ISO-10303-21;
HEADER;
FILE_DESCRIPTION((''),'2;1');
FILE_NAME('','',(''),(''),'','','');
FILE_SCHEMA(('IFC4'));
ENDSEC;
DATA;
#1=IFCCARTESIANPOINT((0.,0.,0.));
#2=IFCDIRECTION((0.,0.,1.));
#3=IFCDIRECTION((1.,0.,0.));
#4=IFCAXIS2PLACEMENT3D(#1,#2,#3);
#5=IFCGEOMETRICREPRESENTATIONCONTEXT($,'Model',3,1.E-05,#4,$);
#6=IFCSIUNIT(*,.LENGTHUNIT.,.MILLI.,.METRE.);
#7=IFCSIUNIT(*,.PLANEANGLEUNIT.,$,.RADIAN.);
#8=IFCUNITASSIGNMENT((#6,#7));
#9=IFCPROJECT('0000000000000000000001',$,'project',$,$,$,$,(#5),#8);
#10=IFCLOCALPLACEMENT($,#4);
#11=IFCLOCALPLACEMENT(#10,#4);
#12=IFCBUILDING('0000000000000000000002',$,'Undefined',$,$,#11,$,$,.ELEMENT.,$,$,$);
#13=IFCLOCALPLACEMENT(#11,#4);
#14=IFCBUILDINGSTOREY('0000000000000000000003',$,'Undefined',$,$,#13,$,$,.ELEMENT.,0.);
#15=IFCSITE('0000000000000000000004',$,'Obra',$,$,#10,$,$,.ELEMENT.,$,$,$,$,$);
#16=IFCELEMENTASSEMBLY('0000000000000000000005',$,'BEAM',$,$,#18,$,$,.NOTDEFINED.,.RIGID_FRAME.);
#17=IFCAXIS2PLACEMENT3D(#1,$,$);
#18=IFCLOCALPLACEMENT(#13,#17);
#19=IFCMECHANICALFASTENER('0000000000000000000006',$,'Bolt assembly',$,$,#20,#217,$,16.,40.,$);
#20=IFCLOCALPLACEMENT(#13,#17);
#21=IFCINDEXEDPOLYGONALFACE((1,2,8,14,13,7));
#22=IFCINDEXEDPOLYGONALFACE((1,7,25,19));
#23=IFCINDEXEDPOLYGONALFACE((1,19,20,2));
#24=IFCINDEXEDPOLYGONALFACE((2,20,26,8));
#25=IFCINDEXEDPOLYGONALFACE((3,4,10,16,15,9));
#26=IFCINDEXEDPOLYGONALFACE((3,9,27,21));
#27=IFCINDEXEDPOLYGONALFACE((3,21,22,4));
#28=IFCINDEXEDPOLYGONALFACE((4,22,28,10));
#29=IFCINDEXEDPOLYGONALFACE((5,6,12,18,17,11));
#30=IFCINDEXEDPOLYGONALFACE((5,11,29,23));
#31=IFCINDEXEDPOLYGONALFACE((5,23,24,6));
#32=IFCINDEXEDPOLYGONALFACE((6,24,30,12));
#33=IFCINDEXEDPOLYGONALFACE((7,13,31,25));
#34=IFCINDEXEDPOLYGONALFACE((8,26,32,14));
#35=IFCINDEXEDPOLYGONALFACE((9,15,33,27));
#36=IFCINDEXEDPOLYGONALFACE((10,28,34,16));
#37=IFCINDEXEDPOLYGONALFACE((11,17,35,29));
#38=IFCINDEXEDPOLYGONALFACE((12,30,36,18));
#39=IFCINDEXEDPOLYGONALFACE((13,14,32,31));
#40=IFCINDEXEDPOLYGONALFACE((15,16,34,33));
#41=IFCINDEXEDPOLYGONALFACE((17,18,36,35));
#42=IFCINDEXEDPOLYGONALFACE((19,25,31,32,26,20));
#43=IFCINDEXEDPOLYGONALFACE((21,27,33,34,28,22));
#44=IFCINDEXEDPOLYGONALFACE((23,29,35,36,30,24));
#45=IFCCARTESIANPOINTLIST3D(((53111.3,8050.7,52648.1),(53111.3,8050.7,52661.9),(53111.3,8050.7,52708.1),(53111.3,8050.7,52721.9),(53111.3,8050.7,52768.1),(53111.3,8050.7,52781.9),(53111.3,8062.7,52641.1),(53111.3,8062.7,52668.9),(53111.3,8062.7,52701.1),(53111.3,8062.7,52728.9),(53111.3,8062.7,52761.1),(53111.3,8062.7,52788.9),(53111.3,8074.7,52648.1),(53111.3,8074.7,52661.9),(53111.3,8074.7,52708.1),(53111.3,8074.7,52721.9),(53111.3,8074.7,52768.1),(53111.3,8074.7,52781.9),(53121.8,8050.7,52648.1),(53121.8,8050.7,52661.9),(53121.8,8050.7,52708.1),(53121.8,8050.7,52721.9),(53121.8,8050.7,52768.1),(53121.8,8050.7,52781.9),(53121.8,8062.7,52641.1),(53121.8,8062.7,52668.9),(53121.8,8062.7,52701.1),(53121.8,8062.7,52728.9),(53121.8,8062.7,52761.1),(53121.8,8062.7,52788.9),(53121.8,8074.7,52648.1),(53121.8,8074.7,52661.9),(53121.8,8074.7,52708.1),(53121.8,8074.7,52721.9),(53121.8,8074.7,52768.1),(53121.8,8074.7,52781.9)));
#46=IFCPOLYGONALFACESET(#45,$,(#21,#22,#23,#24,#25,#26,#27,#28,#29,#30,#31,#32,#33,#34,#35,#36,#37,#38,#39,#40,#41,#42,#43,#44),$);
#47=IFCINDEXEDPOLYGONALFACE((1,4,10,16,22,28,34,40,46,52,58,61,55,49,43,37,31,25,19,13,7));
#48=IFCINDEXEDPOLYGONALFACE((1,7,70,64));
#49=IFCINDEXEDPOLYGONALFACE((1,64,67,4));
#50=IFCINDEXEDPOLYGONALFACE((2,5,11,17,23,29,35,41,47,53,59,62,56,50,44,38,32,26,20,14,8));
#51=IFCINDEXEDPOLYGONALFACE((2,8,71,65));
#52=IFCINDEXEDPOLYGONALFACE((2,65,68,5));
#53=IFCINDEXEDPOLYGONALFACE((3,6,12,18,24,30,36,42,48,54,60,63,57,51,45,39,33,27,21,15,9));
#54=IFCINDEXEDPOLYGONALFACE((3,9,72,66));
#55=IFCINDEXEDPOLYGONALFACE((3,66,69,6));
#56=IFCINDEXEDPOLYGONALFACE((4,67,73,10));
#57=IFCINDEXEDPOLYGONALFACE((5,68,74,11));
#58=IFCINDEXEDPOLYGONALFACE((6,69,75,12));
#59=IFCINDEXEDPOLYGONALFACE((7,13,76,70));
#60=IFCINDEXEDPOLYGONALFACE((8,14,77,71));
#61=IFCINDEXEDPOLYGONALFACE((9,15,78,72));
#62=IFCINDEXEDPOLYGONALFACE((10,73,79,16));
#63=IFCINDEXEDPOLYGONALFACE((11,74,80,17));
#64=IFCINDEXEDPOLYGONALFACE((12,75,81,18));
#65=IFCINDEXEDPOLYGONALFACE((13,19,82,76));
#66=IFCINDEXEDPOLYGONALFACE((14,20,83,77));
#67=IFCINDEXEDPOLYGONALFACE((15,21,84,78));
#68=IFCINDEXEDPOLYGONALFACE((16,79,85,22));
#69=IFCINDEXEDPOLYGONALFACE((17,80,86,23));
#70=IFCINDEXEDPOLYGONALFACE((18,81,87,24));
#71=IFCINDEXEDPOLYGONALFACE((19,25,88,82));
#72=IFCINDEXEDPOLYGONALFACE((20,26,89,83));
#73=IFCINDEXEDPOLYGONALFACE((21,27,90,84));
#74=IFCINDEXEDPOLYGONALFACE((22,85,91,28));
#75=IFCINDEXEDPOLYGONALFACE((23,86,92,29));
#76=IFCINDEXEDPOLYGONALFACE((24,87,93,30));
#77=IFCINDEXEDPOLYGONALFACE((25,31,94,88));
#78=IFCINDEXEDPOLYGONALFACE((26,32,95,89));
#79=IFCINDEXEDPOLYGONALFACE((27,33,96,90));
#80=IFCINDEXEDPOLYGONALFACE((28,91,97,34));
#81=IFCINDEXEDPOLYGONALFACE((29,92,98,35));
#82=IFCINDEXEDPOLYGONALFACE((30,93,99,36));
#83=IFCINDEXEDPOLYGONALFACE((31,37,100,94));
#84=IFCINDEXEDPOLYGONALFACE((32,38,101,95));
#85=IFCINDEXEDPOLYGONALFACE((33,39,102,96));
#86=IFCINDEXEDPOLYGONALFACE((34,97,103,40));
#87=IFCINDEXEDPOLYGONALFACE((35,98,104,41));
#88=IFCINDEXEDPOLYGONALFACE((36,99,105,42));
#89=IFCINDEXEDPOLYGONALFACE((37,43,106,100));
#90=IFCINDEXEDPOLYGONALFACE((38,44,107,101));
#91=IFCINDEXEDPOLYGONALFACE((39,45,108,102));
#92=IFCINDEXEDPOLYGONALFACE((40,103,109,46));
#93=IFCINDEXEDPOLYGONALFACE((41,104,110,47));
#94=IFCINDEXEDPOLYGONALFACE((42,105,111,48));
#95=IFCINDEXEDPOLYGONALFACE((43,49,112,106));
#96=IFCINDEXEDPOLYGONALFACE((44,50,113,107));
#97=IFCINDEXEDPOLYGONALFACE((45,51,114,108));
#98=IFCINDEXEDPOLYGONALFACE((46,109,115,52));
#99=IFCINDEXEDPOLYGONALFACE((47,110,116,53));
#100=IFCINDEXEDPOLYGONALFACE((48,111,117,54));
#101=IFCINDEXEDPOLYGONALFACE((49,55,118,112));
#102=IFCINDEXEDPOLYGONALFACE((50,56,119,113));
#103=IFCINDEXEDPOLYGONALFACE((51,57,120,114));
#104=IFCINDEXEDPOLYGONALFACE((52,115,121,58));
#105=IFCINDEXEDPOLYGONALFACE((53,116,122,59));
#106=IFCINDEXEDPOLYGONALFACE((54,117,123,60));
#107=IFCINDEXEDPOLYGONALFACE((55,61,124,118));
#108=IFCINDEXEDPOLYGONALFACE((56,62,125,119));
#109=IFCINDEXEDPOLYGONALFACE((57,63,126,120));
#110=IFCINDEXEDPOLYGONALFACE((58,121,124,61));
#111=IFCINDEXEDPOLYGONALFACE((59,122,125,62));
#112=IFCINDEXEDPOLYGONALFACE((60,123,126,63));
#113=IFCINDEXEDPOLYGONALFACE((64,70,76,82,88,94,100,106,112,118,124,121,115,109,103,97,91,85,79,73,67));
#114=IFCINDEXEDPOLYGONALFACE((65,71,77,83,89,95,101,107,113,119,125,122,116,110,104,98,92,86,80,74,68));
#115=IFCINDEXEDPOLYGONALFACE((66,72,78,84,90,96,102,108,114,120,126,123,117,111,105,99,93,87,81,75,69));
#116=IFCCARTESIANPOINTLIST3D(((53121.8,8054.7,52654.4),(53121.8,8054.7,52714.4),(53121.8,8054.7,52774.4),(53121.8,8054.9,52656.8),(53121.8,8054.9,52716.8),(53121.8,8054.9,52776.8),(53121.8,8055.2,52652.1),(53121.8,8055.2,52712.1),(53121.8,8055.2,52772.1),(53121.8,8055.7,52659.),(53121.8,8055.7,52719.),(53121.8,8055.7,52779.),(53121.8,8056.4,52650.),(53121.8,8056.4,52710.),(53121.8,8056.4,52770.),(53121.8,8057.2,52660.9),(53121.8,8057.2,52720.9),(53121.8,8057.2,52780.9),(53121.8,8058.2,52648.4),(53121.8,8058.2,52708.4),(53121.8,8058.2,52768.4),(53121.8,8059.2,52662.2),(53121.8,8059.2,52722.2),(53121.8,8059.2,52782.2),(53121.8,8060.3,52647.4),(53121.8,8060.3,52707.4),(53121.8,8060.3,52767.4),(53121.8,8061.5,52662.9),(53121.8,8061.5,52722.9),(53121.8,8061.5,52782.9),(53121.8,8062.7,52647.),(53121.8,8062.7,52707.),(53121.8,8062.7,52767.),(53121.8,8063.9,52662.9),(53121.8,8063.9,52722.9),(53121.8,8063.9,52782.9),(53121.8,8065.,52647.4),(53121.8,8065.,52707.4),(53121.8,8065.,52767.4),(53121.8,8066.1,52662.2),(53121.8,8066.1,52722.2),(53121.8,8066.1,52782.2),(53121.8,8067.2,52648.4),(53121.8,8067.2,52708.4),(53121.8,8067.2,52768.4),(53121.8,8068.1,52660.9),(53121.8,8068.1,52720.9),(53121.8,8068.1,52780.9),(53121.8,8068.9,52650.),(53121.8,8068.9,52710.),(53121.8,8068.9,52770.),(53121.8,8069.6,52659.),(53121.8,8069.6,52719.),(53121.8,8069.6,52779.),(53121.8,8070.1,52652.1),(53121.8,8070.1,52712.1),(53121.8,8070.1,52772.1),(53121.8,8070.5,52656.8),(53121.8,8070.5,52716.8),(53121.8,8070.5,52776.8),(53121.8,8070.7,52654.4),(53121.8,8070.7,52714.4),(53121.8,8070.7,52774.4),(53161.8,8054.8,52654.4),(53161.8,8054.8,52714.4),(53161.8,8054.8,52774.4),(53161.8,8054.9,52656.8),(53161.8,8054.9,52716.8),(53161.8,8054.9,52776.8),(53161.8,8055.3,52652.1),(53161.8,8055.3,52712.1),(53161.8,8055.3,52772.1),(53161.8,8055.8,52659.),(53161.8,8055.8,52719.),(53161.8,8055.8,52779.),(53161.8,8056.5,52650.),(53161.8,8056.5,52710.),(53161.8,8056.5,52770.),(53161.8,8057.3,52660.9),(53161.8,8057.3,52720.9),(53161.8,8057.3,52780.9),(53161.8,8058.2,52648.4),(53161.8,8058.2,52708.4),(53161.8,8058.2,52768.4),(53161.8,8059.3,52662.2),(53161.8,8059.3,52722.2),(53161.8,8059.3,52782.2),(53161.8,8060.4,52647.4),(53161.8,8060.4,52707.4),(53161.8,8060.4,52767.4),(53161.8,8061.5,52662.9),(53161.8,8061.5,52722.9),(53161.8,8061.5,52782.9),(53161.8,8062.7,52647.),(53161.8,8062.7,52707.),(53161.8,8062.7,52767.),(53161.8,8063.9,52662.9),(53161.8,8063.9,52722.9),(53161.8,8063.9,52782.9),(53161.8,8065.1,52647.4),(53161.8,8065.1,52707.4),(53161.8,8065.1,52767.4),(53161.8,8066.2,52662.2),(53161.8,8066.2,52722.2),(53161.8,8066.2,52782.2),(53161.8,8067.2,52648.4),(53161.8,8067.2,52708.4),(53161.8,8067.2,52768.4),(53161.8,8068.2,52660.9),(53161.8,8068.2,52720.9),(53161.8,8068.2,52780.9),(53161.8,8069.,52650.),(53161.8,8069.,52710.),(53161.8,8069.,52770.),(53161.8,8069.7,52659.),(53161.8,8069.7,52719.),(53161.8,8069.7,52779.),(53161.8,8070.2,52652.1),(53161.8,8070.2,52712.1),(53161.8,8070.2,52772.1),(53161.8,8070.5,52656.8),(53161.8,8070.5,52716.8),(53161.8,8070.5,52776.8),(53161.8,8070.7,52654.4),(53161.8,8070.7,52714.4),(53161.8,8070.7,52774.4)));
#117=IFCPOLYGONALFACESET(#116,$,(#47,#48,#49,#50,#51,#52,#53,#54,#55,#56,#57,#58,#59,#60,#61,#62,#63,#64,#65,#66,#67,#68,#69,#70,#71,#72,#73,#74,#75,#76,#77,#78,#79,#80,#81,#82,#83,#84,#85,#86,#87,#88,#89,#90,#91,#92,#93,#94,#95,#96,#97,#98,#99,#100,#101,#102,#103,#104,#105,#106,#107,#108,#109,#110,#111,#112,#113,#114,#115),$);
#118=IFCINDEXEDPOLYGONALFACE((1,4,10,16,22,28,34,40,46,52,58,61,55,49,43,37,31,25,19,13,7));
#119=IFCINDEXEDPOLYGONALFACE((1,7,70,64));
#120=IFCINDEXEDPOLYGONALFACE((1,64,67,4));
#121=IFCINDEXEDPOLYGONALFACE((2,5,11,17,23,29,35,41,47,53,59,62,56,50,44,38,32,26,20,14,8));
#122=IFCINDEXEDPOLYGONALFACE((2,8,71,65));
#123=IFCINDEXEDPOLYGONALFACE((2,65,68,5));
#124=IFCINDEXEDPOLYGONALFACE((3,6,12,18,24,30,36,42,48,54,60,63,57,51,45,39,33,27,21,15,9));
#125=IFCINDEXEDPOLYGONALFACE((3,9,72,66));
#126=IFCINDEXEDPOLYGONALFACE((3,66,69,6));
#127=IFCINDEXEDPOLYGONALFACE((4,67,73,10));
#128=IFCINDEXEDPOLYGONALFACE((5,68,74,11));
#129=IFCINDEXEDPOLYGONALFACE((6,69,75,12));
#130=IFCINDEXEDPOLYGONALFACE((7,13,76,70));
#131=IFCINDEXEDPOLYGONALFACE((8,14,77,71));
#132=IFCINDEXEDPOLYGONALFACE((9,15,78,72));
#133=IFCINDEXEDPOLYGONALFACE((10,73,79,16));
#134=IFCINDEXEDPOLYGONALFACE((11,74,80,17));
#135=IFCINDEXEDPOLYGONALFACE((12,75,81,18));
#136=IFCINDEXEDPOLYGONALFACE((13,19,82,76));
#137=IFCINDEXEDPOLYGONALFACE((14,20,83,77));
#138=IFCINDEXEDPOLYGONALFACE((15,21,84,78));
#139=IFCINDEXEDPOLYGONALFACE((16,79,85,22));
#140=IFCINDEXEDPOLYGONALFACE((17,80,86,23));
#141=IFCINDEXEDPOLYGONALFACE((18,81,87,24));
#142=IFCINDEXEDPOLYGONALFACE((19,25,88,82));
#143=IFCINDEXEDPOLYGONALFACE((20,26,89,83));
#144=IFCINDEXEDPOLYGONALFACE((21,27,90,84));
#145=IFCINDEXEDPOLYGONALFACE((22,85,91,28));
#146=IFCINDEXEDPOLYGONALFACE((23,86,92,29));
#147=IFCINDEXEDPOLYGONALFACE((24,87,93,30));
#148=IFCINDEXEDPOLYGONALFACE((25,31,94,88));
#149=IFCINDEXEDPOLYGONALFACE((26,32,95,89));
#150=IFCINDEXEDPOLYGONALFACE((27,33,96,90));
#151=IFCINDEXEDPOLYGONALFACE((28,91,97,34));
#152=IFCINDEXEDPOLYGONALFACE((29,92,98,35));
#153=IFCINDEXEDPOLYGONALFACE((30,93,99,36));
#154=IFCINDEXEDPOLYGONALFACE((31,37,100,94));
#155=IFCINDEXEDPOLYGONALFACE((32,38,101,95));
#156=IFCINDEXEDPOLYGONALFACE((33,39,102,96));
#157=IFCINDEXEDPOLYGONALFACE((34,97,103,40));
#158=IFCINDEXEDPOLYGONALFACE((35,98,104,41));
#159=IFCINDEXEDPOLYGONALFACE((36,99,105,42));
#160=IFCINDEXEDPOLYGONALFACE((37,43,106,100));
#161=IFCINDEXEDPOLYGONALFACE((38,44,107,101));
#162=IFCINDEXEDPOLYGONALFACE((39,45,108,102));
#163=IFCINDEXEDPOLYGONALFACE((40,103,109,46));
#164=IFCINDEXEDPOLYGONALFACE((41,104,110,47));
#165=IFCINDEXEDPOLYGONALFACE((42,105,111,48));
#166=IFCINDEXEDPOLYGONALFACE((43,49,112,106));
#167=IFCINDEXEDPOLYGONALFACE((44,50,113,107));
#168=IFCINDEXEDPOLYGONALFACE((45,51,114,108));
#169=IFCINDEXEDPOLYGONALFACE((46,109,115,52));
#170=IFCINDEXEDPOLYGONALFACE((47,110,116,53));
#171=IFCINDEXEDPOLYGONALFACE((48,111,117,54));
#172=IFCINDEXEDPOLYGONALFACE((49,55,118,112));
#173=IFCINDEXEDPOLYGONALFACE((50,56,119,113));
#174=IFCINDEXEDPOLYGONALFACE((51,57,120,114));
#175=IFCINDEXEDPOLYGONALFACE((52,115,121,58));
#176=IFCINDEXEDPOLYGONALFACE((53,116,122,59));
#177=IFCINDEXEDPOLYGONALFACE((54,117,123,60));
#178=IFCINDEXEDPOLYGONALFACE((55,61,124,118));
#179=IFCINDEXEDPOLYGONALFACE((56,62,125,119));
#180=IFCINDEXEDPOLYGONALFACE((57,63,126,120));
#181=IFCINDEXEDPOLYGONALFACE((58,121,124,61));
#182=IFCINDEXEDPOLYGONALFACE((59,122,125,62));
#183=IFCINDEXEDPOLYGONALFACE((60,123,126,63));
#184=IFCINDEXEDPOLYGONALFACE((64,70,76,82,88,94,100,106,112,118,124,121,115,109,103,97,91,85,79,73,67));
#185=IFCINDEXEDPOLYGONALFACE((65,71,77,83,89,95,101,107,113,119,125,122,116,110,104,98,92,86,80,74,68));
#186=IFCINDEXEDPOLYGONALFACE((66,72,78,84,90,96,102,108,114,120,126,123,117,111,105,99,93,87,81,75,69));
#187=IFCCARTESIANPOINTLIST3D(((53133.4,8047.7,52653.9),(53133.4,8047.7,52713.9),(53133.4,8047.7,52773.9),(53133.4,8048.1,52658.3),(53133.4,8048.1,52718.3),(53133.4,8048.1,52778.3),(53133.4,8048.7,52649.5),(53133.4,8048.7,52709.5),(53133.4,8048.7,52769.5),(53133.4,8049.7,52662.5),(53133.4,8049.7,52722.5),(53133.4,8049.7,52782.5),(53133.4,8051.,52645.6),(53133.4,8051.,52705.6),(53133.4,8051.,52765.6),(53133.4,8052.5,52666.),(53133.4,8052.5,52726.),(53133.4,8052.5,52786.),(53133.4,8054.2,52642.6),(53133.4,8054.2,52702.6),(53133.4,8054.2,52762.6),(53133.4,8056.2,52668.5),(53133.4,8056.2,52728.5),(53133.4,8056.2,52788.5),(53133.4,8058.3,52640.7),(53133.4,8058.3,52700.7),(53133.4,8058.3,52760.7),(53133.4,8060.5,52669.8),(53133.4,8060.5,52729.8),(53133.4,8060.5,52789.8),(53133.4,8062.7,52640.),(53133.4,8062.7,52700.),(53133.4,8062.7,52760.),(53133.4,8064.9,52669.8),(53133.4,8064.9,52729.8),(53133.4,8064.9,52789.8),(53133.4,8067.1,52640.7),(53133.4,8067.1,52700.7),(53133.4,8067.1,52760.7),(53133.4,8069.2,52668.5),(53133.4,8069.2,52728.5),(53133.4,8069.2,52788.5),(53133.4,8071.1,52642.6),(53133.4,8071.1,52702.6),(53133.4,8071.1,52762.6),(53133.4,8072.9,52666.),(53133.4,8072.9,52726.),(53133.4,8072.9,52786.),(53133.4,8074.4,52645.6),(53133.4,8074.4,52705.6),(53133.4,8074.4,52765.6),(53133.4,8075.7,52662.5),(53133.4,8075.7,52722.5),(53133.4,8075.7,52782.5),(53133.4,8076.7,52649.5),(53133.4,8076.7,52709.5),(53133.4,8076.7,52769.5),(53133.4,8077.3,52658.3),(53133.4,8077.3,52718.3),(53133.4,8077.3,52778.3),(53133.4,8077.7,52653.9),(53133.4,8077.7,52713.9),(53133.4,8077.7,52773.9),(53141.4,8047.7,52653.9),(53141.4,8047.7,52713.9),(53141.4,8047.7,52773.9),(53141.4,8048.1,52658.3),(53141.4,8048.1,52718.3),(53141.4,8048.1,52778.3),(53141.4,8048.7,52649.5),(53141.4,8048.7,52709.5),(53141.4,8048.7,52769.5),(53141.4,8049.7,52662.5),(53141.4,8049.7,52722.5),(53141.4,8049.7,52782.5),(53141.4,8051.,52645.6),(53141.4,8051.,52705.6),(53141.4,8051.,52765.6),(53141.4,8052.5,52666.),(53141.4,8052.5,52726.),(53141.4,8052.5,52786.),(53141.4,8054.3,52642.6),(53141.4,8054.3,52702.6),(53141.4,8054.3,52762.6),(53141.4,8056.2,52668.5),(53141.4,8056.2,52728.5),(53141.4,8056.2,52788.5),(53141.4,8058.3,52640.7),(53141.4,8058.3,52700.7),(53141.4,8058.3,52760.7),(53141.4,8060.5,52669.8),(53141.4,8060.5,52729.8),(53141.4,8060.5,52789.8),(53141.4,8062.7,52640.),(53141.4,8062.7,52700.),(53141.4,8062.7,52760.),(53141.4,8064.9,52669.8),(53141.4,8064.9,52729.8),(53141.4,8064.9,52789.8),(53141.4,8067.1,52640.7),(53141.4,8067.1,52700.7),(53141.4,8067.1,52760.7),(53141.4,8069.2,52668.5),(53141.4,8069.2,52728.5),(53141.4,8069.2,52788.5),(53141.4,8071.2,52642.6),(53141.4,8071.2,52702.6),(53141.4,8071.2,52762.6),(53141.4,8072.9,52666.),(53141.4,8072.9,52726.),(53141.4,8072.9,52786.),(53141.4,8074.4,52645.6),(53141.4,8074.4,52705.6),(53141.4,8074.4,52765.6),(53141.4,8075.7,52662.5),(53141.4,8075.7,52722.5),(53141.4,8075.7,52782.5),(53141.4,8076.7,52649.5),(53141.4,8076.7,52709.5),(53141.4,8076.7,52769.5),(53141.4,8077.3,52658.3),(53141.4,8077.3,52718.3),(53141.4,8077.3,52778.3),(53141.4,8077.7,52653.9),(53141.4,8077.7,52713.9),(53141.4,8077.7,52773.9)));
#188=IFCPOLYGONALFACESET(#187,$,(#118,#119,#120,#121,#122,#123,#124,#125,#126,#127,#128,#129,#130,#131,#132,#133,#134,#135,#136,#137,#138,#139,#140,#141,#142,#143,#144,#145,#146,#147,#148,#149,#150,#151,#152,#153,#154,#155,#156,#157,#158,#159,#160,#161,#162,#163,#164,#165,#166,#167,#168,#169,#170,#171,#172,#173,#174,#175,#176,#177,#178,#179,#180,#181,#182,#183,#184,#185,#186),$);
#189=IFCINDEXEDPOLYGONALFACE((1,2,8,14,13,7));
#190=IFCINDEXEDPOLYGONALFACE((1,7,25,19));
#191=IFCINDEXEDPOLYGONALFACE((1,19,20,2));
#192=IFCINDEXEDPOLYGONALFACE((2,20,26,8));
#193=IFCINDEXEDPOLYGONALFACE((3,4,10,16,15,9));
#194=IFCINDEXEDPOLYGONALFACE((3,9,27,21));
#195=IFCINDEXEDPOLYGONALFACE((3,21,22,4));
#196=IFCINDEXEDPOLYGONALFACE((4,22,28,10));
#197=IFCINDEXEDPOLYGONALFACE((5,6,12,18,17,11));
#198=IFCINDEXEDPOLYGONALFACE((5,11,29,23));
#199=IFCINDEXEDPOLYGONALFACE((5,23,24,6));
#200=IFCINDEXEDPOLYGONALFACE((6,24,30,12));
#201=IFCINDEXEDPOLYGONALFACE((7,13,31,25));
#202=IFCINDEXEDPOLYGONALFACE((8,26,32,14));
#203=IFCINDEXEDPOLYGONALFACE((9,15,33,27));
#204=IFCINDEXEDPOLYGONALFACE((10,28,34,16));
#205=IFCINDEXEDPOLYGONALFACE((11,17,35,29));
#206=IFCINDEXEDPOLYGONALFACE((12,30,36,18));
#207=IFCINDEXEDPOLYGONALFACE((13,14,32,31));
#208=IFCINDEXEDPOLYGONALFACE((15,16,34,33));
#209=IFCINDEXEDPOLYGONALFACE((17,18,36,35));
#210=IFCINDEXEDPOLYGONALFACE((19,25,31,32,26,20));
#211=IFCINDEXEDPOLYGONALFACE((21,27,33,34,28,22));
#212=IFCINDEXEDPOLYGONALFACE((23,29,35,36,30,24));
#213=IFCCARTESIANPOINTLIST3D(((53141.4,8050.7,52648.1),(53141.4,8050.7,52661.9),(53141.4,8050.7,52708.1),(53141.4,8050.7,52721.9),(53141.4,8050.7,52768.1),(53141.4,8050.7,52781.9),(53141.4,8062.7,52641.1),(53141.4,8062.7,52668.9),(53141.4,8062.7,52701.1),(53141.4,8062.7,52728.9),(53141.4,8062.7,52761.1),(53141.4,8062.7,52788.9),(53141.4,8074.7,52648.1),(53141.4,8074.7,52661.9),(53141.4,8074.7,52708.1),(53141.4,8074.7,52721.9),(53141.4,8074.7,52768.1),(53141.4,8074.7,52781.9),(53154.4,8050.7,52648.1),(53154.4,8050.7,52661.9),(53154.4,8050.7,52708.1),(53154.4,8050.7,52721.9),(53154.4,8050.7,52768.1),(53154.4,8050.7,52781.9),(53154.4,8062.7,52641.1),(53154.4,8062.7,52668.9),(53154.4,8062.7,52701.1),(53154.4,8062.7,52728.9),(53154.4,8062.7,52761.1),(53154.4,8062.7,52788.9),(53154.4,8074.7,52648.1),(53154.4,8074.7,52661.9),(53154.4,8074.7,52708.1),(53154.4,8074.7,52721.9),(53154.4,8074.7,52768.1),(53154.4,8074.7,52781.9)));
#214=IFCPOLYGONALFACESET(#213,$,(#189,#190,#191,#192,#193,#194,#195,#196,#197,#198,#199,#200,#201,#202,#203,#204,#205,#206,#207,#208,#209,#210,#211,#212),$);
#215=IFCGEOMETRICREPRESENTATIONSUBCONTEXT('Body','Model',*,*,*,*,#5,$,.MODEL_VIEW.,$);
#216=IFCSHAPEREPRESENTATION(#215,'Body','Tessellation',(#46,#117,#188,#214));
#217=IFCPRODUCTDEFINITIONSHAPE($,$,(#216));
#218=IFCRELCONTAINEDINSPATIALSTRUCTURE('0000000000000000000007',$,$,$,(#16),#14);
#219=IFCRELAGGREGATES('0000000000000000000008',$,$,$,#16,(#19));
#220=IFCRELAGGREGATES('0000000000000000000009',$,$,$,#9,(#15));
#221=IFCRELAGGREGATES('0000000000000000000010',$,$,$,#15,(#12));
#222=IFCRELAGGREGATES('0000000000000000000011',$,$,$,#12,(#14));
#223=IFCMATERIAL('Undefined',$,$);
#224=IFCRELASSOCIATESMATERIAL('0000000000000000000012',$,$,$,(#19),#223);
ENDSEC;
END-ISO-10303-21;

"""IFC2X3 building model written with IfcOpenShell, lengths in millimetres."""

from ifc_helpers import new_model, si_unit, frame, origin_with_axes, origin_2d_with_axis, place, context, subcontext, project, spatial, polyline, circle, outline, extrude, source, transform, mapped, material, element, aggregate, save


model = new_model("IFC2X3")

# Units and contexts
model_context = context("Model", 3, precision=1e-05, world=origin_with_axes())
body_context = subcontext(model_context, "Body", "Model", "MODEL_VIEW")
ifc_project = project(units=[si_unit("LENGTHUNIT", "METRE", prefix="MILLI"), si_unit("PLANEANGLEUNIT", "RADIAN")], contexts=[model_context])

# Site, building, storey
site_placement = place(None, origin_with_axes())
site = spatial("IfcSite", under=ifc_project, at=site_placement, Name="Obra", CompositionType="ELEMENT")
building_placement = place(site_placement, origin_with_axes())
building = spatial("IfcBuilding", under=site, at=building_placement, Name="Undefined", CompositionType="ELEMENT")
storey_placement = place(building_placement, origin_with_axes())
storey = spatial("IfcBuildingStorey", under=building, at=storey_placement, Name="Undefined", CompositionType="ELEMENT", Elevation=0.0)

# Element assembly
assembly_1_placement = place(storey_placement, origin_with_axes())
assembly_1 = element("IfcElementAssembly", 1, at=assembly_1_placement, inside=storey, Name="BEAM", AssemblyPlace="NOTDEFINED", PredefinedType="RIGID_FRAME")

# Mechanical fastener
ifc_material_1 = material(Name="Undefined")
shared_shape_1 = source(origin_with_axes(), body_context, "Body", "SweptSolid", [
    extrude(outline(polyline([(13.9, 0.0), (6.9, 12.0), (-6.9, 12.0), (-13.9, 0.0), (-6.9, -12.0), (6.9, -12.0), (13.9, 0.0)])), frame((0.0, -19.7, 0.0), z_axis=(0.0, 1.0, 0.0), x_axis=(1.0, 0.0, 0.0)), (0.0, 0.0, 1.0), 10.6),
    extrude(circle(Radius=8.0, at=origin_2d_with_axis()), frame((0.0, -9.1, 0.0), z_axis=(0.0, 1.0, 0.0), x_axis=(1.0, 0.0, 0.0)), (0.0, 0.0, 1.0), 40.0),
    extrude(circle(Radius=15.0, at=origin_2d_with_axis()), frame((0.0, 2.5, 0.0), z_axis=(0.0, 1.0, 0.0), x_axis=(1.0, 0.0, 0.0)), (0.0, 0.0, 1.0), 8.0),
    extrude(outline(polyline([(13.9, 0.0), (6.9, 12.0), (-6.9, 12.0), (-13.9, 0.0), (-6.9, -12.0), (6.9, -12.0), (13.9, 0.0)])), frame((0.0, 10.5, 0.0), z_axis=(0.0, 1.0, 0.0), x_axis=(1.0, 0.0, 0.0)), (0.0, 0.0, 1.0), 13.0),
])
mechanical_fastener_1_placement = place(assembly_1_placement, frame((53130.9, 8112.7, 52835.0), z_axis=(0.001508, -0.999999, 0.0), x_axis=(0.0, 0.0, -1.0)))
mechanical_fastener_1 = element("IfcMechanicalFastener", 2, at=mechanical_fastener_1_placement, material=ifc_material_1, Name="Bolt assembly", NominalDiameter=16.0, NominalLength=40.0, context=body_context, shape_type="MappedRepresentation", body=[
    mapped(shared_shape_1, transform((60.0, 0.0, 50.0))),
    mapped(shared_shape_1, transform((120.0, 0.0, 50.0))),
    mapped(shared_shape_1, transform((180.0, 0.0, 50.0))),
])
aggregate(assembly_1, [mechanical_fastener_1])

save(model, "model.ifc")
